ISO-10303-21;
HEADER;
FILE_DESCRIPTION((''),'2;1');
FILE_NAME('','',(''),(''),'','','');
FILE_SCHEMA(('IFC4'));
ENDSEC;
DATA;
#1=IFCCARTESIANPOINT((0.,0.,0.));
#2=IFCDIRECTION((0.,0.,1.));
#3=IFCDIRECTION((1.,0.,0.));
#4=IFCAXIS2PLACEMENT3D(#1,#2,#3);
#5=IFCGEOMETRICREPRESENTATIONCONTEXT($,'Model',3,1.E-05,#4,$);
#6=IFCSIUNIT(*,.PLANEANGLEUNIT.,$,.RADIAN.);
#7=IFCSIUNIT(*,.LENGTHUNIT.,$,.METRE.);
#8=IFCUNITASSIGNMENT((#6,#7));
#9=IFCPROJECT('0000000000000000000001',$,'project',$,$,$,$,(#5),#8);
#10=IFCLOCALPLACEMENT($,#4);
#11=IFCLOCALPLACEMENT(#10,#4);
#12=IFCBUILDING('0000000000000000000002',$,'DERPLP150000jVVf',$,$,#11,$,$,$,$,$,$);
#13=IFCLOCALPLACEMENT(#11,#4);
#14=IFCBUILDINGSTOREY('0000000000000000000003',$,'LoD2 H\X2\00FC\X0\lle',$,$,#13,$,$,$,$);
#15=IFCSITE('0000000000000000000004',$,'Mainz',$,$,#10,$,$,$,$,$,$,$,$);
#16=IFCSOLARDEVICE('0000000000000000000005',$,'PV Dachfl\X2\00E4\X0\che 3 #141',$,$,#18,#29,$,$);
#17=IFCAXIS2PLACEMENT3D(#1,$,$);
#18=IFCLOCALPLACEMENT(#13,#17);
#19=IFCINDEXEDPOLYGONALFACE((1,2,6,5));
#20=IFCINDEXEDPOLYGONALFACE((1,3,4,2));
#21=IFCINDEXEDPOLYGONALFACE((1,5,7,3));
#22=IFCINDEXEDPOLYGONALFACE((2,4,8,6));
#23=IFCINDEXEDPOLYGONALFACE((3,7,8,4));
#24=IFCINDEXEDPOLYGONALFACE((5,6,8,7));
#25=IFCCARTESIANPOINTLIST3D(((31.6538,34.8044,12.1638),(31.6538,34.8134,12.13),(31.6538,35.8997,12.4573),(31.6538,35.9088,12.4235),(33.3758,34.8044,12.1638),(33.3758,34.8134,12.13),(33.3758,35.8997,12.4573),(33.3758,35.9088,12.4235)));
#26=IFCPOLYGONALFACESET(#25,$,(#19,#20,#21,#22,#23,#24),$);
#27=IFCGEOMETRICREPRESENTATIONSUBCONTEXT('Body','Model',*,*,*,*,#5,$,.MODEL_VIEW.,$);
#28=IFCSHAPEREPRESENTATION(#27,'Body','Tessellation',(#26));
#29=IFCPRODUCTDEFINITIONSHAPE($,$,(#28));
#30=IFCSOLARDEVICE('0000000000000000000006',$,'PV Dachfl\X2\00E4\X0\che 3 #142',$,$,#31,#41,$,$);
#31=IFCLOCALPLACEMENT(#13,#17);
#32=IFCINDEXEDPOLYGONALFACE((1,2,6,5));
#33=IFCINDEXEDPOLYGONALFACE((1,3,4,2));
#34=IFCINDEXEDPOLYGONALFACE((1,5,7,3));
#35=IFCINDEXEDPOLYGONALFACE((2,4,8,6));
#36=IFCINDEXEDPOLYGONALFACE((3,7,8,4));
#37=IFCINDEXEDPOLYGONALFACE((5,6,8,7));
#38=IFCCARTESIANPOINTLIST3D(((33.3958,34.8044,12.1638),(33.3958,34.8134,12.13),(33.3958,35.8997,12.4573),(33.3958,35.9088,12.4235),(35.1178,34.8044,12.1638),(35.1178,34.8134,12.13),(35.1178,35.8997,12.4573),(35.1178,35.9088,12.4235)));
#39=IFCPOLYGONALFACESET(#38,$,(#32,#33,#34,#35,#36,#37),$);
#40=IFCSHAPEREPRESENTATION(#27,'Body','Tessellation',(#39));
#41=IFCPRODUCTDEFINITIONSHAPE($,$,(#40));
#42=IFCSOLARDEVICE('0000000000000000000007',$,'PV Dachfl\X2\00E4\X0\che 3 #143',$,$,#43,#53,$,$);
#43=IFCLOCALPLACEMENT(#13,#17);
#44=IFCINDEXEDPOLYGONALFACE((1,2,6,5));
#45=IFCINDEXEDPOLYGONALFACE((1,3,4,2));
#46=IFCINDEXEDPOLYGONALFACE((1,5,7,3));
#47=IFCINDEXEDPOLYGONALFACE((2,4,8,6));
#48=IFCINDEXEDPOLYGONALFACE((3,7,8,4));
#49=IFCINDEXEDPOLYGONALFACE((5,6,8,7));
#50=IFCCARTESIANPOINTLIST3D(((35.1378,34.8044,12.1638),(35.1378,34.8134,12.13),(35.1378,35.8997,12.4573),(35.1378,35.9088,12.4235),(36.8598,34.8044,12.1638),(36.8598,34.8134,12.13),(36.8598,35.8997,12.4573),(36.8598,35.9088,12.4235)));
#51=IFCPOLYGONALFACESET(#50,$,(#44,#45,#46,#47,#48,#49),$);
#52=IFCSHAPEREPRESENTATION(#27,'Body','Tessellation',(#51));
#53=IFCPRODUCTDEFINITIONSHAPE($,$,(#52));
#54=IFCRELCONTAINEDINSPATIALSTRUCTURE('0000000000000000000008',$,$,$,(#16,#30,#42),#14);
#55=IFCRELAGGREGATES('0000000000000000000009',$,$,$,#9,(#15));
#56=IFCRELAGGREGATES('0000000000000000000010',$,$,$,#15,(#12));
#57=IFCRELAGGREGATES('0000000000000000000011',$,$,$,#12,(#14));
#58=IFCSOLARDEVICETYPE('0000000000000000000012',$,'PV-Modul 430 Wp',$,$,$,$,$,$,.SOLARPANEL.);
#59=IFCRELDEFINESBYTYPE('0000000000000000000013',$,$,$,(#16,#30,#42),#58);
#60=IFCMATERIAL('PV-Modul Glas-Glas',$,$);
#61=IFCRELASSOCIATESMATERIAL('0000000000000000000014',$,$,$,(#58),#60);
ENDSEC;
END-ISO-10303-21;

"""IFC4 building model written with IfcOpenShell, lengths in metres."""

from ifc_helpers import new_model, si_unit, frame, frame_2d, origin, origin_with_axes, place, context, subcontext, project, spatial, rectangle, extrude, source, transform, mapped, material, type_object, type_shapes, element, save


model = new_model("IFC4")

# Units and contexts
model_context = context("Model", 3, precision=1e-05, world=origin_with_axes())
body_context = subcontext(model_context, "Body", "Model", "MODEL_VIEW")
ifc_project = project(units=[si_unit("PLANEANGLEUNIT", "RADIAN"), si_unit("LENGTHUNIT", "METRE")], contexts=[model_context])

# Site, building, storey
site_placement = place(None, origin_with_axes())
site = spatial("IfcSite", under=ifc_project, at=site_placement, Name="Mainz")
building_placement = place(site_placement, origin_with_axes())
building = spatial("IfcBuilding", under=site, at=building_placement, Name="DERPLP150000jVVf")
storey_placement = place(building_placement, origin_with_axes())
storey = spatial("IfcBuildingStorey", under=building, at=storey_placement, Name="LoD2 Hülle")

# Solar devices
ifc_material = material(Name="PV-Modul Glas-Glas")
solar_device_type = type_object("IfcSolarDeviceType", Name="PV-Modul 430 Wp", PredefinedType="SOLARPANEL", material=ifc_material)
shared_shape = source(origin_with_axes(), body_context, "Body", "SweptSolid", [
    extrude(rectangle(XDim=1.722, YDim=1.134, at=frame_2d((0.861, 0.567))), origin(), (0.0, 0.0, 1.0), 0.035),
])
type_shapes(solar_device_type, [shared_shape])
for number, where, z_axis, x_axis, name in (
    (1, (31.6538, 34.8134, 12.13), (0.0, -0.258819, 0.965926), (1.0, 0.0, 0.0), "PV Dachfläche 3 #141"),
    (2, (33.3958, 34.8134, 12.13), (0.0, -0.258819, 0.965926), (1.0, 0.0, 0.0), "PV Dachfläche 3 #142"),
    (3, (35.1378, 34.8134, 12.13), (0.0, -0.258819, 0.965926), (1.0, 0.0, 0.0), "PV Dachfläche 3 #143"),
):
    element("IfcSolarDevice", number, at=place(storey_placement, frame(where, z_axis=z_axis, x_axis=x_axis)), inside=storey, type_object=solar_device_type, Name=name, context=body_context, shape_type="MappedRepresentation", body=[
        mapped(shared_shape, transform((0.0, 0.0, 0.0), x_axis=(1.0, 0.0, 0.0), y_axis=(0.0, 1.0, 0.0), z_axis=(0.0, 0.0, 1.0), scale=1.0)),
    ])

save(model, "model.ifc")
